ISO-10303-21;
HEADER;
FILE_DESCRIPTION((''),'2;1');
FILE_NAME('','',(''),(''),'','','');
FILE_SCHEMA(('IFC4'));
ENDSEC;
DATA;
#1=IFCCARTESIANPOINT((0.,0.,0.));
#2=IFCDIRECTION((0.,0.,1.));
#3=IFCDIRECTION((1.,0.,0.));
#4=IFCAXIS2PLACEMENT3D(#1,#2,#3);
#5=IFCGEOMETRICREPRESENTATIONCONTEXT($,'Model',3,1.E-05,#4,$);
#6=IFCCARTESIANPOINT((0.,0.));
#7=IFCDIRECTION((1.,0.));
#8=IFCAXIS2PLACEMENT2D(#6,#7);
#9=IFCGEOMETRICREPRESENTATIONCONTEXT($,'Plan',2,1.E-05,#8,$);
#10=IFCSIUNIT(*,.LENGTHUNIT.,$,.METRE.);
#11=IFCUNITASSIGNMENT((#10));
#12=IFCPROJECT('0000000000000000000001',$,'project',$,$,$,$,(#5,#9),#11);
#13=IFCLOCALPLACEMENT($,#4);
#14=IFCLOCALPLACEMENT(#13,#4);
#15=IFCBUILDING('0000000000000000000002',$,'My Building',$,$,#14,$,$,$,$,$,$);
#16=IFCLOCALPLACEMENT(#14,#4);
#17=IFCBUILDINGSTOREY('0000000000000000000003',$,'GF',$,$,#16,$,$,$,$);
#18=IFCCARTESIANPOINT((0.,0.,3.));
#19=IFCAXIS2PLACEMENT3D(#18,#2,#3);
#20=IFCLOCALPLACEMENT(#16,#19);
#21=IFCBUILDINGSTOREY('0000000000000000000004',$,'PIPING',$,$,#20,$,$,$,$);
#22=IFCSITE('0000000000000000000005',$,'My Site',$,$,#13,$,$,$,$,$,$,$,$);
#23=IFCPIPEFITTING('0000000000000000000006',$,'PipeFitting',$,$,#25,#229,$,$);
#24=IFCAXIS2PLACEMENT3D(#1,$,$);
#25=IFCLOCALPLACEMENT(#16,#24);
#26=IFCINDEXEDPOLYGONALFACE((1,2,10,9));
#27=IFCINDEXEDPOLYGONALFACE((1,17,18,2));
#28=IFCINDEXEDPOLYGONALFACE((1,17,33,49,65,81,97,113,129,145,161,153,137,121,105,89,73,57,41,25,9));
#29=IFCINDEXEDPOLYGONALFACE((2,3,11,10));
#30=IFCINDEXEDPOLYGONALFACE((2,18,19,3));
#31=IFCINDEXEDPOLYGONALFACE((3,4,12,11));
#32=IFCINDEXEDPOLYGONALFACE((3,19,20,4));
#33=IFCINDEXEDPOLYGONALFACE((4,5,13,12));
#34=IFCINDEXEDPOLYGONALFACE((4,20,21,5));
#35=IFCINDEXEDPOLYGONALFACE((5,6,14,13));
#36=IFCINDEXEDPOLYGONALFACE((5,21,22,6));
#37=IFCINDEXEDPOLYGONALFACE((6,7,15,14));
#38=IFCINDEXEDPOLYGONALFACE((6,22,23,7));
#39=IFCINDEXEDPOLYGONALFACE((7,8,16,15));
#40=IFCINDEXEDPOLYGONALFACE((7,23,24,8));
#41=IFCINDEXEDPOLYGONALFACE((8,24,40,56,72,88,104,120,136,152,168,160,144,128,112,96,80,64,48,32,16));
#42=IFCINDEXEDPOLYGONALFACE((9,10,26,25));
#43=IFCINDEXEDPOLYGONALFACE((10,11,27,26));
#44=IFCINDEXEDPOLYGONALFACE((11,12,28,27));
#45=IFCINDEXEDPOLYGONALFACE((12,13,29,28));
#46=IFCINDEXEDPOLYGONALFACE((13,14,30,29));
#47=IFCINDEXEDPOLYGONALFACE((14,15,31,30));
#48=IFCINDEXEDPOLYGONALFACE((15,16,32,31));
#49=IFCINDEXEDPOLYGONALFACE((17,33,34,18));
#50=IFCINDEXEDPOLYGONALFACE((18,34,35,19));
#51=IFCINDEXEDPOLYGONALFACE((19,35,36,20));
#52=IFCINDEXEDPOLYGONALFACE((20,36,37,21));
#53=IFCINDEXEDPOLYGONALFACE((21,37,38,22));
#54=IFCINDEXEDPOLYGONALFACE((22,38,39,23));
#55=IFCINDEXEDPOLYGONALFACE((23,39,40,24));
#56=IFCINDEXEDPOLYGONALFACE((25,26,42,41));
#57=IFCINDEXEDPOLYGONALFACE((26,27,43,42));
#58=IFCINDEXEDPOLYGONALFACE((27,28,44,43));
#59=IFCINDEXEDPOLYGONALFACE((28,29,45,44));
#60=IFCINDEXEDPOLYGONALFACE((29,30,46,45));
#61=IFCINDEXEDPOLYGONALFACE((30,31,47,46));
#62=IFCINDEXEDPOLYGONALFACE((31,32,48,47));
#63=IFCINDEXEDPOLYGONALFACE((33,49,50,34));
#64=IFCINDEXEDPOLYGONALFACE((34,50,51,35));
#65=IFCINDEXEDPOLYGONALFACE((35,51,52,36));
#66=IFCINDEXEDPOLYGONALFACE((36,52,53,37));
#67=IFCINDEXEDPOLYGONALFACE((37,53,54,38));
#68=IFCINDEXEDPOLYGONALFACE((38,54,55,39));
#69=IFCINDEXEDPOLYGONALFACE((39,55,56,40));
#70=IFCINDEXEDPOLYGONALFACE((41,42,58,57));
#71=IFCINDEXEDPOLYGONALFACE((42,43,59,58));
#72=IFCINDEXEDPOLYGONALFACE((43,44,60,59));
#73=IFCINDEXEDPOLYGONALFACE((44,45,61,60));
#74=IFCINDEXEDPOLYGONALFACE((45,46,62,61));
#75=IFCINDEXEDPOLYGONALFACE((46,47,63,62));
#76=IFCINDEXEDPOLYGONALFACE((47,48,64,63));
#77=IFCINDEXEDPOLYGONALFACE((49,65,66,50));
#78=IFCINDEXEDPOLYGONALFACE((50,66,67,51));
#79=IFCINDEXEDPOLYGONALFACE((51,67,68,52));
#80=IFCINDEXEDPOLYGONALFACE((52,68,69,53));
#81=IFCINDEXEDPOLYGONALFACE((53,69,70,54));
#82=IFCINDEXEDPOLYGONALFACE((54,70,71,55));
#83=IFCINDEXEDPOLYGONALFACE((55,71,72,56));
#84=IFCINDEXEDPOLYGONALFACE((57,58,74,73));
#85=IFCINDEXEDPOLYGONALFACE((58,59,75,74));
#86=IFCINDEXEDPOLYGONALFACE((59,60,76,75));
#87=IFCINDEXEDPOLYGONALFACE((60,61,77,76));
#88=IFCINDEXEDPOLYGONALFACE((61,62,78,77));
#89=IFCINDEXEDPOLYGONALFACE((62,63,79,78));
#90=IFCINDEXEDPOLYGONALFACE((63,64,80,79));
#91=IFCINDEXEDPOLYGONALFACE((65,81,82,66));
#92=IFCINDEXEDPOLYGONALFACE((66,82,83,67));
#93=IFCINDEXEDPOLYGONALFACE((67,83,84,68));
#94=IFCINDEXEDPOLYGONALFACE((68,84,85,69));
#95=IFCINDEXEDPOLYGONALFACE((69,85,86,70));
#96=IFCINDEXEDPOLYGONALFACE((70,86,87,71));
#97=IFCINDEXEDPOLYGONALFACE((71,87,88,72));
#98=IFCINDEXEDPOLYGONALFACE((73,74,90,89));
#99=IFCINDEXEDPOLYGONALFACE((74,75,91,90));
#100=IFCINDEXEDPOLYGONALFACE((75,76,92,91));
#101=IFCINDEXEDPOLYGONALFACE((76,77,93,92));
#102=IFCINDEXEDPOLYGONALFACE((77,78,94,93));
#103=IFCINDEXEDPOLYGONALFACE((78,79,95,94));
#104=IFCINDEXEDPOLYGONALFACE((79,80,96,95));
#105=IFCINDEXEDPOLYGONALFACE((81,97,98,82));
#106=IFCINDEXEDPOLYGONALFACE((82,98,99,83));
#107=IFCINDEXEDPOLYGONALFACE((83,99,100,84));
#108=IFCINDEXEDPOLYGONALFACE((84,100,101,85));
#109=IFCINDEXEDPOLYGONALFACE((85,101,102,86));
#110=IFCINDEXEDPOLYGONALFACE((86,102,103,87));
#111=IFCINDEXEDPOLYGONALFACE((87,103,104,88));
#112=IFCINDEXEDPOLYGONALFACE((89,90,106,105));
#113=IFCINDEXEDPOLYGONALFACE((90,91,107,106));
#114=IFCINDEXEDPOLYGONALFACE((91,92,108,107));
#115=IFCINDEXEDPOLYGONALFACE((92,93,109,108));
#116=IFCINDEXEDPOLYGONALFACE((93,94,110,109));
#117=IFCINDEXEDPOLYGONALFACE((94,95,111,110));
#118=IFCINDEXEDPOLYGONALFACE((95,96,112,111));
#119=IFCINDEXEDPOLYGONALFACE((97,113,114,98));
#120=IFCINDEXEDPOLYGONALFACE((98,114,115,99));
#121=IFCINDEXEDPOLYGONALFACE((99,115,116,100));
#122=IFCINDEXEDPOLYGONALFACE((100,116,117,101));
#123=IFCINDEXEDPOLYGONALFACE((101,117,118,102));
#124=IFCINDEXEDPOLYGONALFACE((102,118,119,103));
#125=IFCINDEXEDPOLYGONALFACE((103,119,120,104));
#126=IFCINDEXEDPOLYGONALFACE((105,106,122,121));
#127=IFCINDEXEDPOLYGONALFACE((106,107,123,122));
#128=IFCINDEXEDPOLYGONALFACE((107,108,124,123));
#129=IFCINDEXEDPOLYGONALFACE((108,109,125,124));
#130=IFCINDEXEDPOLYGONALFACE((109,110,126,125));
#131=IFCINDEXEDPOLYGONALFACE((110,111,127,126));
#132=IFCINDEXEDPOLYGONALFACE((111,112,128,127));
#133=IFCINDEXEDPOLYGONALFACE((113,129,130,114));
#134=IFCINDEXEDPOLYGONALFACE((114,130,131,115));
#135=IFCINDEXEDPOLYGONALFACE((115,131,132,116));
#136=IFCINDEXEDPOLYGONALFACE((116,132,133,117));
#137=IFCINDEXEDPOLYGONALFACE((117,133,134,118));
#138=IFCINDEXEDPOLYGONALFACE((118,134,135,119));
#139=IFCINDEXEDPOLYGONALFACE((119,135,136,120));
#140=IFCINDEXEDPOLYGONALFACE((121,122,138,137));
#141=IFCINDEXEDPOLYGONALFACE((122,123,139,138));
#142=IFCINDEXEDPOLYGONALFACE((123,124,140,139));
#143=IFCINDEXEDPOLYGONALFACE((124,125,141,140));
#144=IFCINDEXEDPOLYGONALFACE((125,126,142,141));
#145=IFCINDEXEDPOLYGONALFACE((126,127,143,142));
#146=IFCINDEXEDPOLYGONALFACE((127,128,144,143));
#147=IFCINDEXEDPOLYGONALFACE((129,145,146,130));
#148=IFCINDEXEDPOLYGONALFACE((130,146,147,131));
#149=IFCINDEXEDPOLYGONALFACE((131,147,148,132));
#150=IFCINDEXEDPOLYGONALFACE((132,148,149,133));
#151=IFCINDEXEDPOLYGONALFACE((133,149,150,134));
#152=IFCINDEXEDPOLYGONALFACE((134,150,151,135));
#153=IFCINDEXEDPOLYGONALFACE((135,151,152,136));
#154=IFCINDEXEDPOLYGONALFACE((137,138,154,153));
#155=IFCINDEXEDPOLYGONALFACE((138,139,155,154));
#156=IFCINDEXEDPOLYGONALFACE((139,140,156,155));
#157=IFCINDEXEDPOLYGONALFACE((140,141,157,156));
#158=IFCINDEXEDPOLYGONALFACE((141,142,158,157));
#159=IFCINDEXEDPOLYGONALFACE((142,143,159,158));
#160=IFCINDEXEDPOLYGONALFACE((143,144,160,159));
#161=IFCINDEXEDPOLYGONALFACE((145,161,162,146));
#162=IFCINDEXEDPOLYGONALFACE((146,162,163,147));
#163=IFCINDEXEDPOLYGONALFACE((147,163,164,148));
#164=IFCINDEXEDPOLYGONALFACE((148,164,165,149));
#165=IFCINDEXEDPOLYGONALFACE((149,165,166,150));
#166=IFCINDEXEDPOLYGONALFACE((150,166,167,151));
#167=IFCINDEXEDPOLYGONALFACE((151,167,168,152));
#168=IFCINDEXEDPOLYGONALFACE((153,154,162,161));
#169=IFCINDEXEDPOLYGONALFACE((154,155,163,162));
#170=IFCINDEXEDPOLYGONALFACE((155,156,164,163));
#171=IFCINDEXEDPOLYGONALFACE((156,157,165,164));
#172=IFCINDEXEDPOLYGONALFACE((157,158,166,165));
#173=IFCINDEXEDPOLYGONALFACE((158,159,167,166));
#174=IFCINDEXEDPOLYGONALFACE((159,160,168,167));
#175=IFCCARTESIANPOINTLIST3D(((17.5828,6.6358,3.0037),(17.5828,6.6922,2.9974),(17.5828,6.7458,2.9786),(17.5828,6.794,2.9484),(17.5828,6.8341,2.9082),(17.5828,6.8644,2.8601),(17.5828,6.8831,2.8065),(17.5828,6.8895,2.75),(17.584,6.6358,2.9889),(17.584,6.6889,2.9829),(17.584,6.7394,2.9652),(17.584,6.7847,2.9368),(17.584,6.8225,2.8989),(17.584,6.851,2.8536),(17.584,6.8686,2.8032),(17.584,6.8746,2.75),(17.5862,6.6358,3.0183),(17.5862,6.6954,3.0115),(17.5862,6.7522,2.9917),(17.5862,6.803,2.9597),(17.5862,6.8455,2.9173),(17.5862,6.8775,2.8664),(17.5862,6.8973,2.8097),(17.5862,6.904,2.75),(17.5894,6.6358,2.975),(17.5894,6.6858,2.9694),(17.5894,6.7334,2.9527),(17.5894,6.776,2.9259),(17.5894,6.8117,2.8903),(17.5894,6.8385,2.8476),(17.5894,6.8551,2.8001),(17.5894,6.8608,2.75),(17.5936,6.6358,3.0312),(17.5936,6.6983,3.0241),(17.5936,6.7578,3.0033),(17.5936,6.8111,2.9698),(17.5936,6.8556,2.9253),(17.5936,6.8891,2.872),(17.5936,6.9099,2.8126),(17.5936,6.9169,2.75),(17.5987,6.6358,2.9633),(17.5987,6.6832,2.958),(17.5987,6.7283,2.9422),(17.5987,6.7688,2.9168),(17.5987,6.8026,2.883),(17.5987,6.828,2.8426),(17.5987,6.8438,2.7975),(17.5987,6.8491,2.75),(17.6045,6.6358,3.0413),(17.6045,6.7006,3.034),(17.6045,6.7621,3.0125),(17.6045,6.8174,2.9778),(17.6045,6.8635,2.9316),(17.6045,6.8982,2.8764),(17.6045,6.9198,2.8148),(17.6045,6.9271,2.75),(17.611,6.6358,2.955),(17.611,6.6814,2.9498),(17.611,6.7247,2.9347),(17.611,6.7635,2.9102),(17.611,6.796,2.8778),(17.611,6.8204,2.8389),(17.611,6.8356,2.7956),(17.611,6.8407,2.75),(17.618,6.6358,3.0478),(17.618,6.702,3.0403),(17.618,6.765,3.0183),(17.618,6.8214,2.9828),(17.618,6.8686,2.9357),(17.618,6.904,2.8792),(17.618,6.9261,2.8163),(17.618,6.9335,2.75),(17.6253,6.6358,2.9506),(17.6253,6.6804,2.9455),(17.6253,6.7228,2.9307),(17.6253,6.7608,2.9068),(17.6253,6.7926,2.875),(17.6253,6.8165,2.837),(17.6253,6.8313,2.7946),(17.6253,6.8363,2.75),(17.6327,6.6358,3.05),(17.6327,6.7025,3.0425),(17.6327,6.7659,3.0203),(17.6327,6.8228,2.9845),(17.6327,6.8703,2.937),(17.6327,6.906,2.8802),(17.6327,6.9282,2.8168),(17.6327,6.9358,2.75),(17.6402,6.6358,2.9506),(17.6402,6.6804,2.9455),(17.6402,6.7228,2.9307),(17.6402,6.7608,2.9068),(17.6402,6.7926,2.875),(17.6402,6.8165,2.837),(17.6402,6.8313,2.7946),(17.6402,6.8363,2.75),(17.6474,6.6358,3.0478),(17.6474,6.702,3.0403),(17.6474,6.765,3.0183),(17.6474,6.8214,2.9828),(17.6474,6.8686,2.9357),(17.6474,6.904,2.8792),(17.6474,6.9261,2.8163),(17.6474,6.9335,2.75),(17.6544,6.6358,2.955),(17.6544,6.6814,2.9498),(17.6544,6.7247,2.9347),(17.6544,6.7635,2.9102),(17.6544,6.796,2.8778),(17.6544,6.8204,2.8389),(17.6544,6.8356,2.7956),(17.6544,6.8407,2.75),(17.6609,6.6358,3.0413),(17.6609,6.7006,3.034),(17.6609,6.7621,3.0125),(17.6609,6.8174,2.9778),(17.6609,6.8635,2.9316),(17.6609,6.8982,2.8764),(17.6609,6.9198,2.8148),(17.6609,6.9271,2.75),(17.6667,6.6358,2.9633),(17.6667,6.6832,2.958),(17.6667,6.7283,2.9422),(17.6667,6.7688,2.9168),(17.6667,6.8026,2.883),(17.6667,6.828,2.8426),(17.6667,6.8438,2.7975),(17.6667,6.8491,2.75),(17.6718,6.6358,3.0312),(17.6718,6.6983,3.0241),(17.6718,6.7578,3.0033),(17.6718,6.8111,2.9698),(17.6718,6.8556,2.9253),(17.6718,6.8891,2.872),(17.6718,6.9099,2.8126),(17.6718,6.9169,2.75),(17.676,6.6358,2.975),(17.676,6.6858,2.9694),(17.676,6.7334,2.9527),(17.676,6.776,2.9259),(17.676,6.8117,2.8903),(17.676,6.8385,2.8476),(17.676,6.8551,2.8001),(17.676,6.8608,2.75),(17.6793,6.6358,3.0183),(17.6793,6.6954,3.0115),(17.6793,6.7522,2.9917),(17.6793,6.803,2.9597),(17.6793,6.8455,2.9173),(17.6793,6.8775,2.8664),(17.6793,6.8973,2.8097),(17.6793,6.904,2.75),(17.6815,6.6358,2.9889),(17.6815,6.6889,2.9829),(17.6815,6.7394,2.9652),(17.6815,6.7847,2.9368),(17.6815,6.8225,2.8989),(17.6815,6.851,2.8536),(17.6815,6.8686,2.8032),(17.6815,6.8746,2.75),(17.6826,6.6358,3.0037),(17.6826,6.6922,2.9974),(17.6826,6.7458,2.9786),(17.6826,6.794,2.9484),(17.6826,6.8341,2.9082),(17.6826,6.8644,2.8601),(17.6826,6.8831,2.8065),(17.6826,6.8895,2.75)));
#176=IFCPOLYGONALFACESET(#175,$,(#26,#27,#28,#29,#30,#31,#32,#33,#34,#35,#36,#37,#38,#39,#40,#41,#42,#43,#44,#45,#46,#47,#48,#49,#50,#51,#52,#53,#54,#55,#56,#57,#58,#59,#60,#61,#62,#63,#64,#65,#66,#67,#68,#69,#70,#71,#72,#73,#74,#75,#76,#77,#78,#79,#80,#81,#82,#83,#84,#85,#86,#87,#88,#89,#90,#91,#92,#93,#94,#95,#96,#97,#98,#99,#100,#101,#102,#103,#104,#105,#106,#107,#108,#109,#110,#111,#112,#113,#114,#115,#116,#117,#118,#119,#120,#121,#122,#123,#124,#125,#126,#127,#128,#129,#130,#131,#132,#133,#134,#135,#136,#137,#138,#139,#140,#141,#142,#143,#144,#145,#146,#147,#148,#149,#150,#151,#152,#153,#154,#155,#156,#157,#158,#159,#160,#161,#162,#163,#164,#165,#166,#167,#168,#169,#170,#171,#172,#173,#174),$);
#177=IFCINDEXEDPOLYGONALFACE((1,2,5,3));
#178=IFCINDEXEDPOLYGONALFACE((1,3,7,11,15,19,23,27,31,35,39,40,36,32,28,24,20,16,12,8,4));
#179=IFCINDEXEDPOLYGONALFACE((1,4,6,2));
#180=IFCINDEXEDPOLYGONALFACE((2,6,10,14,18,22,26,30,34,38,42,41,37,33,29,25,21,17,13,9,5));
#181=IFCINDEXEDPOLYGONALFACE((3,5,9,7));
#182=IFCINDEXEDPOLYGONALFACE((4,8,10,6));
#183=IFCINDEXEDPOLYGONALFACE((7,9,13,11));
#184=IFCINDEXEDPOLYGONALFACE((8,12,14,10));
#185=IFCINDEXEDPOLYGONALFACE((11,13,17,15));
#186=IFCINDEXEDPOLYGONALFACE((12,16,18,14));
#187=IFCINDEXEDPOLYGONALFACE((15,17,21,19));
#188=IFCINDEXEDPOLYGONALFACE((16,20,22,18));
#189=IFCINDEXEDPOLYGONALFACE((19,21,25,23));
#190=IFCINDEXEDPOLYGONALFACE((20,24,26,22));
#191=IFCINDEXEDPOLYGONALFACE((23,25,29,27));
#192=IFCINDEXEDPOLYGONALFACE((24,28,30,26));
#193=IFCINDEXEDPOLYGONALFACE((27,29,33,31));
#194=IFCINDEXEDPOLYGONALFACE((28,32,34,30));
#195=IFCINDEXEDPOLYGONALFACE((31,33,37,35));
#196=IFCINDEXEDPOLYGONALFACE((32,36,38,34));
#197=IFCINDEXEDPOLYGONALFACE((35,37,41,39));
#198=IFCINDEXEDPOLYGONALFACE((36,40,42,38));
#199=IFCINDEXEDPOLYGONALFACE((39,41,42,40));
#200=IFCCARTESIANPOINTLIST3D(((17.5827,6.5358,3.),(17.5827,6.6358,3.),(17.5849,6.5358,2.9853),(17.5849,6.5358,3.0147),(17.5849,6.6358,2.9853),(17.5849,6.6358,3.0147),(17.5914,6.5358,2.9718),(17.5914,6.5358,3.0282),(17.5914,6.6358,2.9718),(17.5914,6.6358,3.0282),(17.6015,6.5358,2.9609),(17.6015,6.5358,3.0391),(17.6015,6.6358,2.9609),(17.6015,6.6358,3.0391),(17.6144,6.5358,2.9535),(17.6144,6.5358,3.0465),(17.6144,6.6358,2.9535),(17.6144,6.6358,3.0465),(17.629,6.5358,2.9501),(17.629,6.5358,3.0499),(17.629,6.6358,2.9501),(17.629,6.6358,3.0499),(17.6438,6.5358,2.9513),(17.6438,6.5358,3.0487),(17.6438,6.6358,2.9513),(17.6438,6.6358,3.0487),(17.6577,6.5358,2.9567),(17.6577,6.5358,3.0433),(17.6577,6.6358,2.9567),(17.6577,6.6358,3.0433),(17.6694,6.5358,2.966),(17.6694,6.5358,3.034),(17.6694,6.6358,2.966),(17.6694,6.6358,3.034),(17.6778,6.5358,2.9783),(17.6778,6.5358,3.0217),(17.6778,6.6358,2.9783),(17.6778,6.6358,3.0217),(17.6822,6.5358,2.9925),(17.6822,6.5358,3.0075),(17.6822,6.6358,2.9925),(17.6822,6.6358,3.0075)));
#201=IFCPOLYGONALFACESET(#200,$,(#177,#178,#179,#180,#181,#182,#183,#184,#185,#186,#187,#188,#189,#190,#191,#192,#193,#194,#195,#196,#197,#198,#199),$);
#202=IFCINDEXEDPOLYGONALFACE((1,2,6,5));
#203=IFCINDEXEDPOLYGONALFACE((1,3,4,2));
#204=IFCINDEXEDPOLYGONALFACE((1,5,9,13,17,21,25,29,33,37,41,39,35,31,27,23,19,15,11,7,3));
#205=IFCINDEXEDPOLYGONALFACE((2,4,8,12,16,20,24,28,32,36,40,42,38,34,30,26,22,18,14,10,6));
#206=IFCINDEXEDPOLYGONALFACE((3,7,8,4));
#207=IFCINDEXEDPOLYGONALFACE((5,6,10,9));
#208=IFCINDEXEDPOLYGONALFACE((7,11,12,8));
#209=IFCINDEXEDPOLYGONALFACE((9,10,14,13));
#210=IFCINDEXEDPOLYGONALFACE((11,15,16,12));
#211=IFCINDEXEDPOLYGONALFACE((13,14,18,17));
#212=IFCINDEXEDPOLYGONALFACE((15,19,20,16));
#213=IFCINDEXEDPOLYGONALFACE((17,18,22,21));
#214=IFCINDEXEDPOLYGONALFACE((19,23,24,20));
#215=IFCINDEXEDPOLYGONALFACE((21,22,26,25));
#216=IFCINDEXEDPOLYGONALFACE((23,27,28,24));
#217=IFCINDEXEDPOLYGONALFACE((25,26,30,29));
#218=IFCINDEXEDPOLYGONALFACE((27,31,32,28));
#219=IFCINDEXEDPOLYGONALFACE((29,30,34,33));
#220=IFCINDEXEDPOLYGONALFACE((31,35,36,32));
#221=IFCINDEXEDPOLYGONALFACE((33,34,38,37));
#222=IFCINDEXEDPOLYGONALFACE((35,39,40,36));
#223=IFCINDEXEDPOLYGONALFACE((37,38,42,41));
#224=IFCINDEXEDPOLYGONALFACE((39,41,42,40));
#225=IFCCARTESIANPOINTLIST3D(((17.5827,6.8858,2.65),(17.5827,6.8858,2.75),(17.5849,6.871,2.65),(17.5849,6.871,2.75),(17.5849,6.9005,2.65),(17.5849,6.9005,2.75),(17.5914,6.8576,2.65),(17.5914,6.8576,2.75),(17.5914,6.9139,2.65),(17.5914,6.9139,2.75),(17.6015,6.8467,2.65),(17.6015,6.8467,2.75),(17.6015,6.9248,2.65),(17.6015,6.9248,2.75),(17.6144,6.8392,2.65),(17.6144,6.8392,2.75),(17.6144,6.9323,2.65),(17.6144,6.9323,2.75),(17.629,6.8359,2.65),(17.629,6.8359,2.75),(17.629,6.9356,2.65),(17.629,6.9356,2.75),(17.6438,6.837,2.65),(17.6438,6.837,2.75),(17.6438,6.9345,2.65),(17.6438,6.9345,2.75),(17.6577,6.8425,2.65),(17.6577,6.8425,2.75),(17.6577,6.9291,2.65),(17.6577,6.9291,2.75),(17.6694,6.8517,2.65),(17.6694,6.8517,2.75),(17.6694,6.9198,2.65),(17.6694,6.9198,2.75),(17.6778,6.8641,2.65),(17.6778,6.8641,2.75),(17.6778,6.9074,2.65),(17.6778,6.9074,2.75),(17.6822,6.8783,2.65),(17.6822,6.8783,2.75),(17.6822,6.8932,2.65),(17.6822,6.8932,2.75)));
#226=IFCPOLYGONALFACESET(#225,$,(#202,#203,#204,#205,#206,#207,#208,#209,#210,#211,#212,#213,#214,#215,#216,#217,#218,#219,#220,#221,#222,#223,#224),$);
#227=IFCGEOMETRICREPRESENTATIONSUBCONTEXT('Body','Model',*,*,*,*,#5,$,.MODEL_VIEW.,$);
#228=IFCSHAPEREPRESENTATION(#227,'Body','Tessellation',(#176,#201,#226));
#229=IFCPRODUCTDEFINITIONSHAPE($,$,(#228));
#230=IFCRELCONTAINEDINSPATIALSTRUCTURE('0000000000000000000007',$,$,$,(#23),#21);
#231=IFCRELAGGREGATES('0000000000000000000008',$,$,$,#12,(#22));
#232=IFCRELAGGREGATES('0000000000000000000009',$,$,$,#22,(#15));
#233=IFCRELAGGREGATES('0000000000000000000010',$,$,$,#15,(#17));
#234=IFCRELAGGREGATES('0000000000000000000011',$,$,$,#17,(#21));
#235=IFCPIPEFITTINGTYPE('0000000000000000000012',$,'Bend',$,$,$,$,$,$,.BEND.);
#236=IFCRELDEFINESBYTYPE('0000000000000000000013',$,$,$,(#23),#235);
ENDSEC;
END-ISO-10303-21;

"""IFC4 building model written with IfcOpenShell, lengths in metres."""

from ifc_helpers import new_model, entity, si_unit, frame, origin_with_axes, origin_2d_with_axis, place, context, subcontext, project, spatial, circle, extrude, source, transform, mapped, type_object, type_shapes, element, save


model = new_model("IFC4")

# Units and contexts
model_context = context("Model", 3, precision=1e-05, world=origin_with_axes())
plan_context = context("Plan", 2, precision=1e-05, world=origin_2d_with_axis())
body_context = subcontext(model_context, "Body", "Model", "MODEL_VIEW")
ifc_project = project(units=[si_unit("LENGTHUNIT", "METRE")], contexts=[model_context, plan_context])

# Site, building, storeys
site_placement = place(None, origin_with_axes())
site = spatial("IfcSite", under=ifc_project, at=site_placement, Name="My Site")
building_placement = place(site_placement, origin_with_axes())
building = spatial("IfcBuilding", under=site, at=building_placement, Name="My Building")
storey_1_placement = place(building_placement, origin_with_axes())
storey_1 = spatial("IfcBuildingStorey", under=building, at=storey_1_placement, Name="GF")
storey_2_placement = place(storey_1_placement, frame((0.0, 0.0, 3.0), z_axis=(0.0, 0.0, 1.0), x_axis=(1.0, 0.0, 0.0)))
storey_2 = spatial("IfcBuildingStorey", under=storey_1, at=storey_2_placement, Name="PIPING")

# Pipe fitting
pipe_fitting_type = type_object("IfcPipeFittingType", Name="Bend", PredefinedType="BEND")
shared_shape = source(origin_with_axes(), body_context, "Body", "SolidModel", [
    entity("IfcSweptDiskSolid", entity("IfcIndexedPolyCurve", entity("IfcCartesianPointList3D", [[0.0, 0.0, -0.1], [0.0, 0.0732, -0.2768], [0.0, 0.25, -0.35]]), [entity("IfcArcIndex", [1, 2, 3])]), 0.05),
    extrude(circle(Radius=0.05), origin_with_axes(), (0.0, 0.0, -1.0), 0.1),
    extrude(circle(Radius=0.05), frame((0.0, 0.25, -0.35), z_axis=(0.0, 1.0, 0.0), x_axis=(1.0, 0.0, 0.0)), (0.0, 0.0, 1.0), 0.1),
])
type_shapes(pipe_fitting_type, [shared_shape])
for number, where, z_axis, x_axis, name in (
    (1, (17.6327, 6.5358, 0.0), (0.0, -1.0, 0.0), (-1.0, 0.0, 0.0), "PipeFitting"),
):
    element("IfcPipeFitting", number, at=place(storey_2_placement, frame(where, z_axis=z_axis, x_axis=x_axis)), inside=storey_2, type_object=pipe_fitting_type, Name=name, context=body_context, shape_type="MappedRepresentation", body=[
        mapped(shared_shape, transform((0.0, 0.0, 0.0), x_axis=(1.0, 0.0, 0.0), y_axis=(0.0, 1.0, 0.0), z_axis=(0.0, 0.0, 1.0), scale=1.0)),
    ])

save(model, "model.ifc")
